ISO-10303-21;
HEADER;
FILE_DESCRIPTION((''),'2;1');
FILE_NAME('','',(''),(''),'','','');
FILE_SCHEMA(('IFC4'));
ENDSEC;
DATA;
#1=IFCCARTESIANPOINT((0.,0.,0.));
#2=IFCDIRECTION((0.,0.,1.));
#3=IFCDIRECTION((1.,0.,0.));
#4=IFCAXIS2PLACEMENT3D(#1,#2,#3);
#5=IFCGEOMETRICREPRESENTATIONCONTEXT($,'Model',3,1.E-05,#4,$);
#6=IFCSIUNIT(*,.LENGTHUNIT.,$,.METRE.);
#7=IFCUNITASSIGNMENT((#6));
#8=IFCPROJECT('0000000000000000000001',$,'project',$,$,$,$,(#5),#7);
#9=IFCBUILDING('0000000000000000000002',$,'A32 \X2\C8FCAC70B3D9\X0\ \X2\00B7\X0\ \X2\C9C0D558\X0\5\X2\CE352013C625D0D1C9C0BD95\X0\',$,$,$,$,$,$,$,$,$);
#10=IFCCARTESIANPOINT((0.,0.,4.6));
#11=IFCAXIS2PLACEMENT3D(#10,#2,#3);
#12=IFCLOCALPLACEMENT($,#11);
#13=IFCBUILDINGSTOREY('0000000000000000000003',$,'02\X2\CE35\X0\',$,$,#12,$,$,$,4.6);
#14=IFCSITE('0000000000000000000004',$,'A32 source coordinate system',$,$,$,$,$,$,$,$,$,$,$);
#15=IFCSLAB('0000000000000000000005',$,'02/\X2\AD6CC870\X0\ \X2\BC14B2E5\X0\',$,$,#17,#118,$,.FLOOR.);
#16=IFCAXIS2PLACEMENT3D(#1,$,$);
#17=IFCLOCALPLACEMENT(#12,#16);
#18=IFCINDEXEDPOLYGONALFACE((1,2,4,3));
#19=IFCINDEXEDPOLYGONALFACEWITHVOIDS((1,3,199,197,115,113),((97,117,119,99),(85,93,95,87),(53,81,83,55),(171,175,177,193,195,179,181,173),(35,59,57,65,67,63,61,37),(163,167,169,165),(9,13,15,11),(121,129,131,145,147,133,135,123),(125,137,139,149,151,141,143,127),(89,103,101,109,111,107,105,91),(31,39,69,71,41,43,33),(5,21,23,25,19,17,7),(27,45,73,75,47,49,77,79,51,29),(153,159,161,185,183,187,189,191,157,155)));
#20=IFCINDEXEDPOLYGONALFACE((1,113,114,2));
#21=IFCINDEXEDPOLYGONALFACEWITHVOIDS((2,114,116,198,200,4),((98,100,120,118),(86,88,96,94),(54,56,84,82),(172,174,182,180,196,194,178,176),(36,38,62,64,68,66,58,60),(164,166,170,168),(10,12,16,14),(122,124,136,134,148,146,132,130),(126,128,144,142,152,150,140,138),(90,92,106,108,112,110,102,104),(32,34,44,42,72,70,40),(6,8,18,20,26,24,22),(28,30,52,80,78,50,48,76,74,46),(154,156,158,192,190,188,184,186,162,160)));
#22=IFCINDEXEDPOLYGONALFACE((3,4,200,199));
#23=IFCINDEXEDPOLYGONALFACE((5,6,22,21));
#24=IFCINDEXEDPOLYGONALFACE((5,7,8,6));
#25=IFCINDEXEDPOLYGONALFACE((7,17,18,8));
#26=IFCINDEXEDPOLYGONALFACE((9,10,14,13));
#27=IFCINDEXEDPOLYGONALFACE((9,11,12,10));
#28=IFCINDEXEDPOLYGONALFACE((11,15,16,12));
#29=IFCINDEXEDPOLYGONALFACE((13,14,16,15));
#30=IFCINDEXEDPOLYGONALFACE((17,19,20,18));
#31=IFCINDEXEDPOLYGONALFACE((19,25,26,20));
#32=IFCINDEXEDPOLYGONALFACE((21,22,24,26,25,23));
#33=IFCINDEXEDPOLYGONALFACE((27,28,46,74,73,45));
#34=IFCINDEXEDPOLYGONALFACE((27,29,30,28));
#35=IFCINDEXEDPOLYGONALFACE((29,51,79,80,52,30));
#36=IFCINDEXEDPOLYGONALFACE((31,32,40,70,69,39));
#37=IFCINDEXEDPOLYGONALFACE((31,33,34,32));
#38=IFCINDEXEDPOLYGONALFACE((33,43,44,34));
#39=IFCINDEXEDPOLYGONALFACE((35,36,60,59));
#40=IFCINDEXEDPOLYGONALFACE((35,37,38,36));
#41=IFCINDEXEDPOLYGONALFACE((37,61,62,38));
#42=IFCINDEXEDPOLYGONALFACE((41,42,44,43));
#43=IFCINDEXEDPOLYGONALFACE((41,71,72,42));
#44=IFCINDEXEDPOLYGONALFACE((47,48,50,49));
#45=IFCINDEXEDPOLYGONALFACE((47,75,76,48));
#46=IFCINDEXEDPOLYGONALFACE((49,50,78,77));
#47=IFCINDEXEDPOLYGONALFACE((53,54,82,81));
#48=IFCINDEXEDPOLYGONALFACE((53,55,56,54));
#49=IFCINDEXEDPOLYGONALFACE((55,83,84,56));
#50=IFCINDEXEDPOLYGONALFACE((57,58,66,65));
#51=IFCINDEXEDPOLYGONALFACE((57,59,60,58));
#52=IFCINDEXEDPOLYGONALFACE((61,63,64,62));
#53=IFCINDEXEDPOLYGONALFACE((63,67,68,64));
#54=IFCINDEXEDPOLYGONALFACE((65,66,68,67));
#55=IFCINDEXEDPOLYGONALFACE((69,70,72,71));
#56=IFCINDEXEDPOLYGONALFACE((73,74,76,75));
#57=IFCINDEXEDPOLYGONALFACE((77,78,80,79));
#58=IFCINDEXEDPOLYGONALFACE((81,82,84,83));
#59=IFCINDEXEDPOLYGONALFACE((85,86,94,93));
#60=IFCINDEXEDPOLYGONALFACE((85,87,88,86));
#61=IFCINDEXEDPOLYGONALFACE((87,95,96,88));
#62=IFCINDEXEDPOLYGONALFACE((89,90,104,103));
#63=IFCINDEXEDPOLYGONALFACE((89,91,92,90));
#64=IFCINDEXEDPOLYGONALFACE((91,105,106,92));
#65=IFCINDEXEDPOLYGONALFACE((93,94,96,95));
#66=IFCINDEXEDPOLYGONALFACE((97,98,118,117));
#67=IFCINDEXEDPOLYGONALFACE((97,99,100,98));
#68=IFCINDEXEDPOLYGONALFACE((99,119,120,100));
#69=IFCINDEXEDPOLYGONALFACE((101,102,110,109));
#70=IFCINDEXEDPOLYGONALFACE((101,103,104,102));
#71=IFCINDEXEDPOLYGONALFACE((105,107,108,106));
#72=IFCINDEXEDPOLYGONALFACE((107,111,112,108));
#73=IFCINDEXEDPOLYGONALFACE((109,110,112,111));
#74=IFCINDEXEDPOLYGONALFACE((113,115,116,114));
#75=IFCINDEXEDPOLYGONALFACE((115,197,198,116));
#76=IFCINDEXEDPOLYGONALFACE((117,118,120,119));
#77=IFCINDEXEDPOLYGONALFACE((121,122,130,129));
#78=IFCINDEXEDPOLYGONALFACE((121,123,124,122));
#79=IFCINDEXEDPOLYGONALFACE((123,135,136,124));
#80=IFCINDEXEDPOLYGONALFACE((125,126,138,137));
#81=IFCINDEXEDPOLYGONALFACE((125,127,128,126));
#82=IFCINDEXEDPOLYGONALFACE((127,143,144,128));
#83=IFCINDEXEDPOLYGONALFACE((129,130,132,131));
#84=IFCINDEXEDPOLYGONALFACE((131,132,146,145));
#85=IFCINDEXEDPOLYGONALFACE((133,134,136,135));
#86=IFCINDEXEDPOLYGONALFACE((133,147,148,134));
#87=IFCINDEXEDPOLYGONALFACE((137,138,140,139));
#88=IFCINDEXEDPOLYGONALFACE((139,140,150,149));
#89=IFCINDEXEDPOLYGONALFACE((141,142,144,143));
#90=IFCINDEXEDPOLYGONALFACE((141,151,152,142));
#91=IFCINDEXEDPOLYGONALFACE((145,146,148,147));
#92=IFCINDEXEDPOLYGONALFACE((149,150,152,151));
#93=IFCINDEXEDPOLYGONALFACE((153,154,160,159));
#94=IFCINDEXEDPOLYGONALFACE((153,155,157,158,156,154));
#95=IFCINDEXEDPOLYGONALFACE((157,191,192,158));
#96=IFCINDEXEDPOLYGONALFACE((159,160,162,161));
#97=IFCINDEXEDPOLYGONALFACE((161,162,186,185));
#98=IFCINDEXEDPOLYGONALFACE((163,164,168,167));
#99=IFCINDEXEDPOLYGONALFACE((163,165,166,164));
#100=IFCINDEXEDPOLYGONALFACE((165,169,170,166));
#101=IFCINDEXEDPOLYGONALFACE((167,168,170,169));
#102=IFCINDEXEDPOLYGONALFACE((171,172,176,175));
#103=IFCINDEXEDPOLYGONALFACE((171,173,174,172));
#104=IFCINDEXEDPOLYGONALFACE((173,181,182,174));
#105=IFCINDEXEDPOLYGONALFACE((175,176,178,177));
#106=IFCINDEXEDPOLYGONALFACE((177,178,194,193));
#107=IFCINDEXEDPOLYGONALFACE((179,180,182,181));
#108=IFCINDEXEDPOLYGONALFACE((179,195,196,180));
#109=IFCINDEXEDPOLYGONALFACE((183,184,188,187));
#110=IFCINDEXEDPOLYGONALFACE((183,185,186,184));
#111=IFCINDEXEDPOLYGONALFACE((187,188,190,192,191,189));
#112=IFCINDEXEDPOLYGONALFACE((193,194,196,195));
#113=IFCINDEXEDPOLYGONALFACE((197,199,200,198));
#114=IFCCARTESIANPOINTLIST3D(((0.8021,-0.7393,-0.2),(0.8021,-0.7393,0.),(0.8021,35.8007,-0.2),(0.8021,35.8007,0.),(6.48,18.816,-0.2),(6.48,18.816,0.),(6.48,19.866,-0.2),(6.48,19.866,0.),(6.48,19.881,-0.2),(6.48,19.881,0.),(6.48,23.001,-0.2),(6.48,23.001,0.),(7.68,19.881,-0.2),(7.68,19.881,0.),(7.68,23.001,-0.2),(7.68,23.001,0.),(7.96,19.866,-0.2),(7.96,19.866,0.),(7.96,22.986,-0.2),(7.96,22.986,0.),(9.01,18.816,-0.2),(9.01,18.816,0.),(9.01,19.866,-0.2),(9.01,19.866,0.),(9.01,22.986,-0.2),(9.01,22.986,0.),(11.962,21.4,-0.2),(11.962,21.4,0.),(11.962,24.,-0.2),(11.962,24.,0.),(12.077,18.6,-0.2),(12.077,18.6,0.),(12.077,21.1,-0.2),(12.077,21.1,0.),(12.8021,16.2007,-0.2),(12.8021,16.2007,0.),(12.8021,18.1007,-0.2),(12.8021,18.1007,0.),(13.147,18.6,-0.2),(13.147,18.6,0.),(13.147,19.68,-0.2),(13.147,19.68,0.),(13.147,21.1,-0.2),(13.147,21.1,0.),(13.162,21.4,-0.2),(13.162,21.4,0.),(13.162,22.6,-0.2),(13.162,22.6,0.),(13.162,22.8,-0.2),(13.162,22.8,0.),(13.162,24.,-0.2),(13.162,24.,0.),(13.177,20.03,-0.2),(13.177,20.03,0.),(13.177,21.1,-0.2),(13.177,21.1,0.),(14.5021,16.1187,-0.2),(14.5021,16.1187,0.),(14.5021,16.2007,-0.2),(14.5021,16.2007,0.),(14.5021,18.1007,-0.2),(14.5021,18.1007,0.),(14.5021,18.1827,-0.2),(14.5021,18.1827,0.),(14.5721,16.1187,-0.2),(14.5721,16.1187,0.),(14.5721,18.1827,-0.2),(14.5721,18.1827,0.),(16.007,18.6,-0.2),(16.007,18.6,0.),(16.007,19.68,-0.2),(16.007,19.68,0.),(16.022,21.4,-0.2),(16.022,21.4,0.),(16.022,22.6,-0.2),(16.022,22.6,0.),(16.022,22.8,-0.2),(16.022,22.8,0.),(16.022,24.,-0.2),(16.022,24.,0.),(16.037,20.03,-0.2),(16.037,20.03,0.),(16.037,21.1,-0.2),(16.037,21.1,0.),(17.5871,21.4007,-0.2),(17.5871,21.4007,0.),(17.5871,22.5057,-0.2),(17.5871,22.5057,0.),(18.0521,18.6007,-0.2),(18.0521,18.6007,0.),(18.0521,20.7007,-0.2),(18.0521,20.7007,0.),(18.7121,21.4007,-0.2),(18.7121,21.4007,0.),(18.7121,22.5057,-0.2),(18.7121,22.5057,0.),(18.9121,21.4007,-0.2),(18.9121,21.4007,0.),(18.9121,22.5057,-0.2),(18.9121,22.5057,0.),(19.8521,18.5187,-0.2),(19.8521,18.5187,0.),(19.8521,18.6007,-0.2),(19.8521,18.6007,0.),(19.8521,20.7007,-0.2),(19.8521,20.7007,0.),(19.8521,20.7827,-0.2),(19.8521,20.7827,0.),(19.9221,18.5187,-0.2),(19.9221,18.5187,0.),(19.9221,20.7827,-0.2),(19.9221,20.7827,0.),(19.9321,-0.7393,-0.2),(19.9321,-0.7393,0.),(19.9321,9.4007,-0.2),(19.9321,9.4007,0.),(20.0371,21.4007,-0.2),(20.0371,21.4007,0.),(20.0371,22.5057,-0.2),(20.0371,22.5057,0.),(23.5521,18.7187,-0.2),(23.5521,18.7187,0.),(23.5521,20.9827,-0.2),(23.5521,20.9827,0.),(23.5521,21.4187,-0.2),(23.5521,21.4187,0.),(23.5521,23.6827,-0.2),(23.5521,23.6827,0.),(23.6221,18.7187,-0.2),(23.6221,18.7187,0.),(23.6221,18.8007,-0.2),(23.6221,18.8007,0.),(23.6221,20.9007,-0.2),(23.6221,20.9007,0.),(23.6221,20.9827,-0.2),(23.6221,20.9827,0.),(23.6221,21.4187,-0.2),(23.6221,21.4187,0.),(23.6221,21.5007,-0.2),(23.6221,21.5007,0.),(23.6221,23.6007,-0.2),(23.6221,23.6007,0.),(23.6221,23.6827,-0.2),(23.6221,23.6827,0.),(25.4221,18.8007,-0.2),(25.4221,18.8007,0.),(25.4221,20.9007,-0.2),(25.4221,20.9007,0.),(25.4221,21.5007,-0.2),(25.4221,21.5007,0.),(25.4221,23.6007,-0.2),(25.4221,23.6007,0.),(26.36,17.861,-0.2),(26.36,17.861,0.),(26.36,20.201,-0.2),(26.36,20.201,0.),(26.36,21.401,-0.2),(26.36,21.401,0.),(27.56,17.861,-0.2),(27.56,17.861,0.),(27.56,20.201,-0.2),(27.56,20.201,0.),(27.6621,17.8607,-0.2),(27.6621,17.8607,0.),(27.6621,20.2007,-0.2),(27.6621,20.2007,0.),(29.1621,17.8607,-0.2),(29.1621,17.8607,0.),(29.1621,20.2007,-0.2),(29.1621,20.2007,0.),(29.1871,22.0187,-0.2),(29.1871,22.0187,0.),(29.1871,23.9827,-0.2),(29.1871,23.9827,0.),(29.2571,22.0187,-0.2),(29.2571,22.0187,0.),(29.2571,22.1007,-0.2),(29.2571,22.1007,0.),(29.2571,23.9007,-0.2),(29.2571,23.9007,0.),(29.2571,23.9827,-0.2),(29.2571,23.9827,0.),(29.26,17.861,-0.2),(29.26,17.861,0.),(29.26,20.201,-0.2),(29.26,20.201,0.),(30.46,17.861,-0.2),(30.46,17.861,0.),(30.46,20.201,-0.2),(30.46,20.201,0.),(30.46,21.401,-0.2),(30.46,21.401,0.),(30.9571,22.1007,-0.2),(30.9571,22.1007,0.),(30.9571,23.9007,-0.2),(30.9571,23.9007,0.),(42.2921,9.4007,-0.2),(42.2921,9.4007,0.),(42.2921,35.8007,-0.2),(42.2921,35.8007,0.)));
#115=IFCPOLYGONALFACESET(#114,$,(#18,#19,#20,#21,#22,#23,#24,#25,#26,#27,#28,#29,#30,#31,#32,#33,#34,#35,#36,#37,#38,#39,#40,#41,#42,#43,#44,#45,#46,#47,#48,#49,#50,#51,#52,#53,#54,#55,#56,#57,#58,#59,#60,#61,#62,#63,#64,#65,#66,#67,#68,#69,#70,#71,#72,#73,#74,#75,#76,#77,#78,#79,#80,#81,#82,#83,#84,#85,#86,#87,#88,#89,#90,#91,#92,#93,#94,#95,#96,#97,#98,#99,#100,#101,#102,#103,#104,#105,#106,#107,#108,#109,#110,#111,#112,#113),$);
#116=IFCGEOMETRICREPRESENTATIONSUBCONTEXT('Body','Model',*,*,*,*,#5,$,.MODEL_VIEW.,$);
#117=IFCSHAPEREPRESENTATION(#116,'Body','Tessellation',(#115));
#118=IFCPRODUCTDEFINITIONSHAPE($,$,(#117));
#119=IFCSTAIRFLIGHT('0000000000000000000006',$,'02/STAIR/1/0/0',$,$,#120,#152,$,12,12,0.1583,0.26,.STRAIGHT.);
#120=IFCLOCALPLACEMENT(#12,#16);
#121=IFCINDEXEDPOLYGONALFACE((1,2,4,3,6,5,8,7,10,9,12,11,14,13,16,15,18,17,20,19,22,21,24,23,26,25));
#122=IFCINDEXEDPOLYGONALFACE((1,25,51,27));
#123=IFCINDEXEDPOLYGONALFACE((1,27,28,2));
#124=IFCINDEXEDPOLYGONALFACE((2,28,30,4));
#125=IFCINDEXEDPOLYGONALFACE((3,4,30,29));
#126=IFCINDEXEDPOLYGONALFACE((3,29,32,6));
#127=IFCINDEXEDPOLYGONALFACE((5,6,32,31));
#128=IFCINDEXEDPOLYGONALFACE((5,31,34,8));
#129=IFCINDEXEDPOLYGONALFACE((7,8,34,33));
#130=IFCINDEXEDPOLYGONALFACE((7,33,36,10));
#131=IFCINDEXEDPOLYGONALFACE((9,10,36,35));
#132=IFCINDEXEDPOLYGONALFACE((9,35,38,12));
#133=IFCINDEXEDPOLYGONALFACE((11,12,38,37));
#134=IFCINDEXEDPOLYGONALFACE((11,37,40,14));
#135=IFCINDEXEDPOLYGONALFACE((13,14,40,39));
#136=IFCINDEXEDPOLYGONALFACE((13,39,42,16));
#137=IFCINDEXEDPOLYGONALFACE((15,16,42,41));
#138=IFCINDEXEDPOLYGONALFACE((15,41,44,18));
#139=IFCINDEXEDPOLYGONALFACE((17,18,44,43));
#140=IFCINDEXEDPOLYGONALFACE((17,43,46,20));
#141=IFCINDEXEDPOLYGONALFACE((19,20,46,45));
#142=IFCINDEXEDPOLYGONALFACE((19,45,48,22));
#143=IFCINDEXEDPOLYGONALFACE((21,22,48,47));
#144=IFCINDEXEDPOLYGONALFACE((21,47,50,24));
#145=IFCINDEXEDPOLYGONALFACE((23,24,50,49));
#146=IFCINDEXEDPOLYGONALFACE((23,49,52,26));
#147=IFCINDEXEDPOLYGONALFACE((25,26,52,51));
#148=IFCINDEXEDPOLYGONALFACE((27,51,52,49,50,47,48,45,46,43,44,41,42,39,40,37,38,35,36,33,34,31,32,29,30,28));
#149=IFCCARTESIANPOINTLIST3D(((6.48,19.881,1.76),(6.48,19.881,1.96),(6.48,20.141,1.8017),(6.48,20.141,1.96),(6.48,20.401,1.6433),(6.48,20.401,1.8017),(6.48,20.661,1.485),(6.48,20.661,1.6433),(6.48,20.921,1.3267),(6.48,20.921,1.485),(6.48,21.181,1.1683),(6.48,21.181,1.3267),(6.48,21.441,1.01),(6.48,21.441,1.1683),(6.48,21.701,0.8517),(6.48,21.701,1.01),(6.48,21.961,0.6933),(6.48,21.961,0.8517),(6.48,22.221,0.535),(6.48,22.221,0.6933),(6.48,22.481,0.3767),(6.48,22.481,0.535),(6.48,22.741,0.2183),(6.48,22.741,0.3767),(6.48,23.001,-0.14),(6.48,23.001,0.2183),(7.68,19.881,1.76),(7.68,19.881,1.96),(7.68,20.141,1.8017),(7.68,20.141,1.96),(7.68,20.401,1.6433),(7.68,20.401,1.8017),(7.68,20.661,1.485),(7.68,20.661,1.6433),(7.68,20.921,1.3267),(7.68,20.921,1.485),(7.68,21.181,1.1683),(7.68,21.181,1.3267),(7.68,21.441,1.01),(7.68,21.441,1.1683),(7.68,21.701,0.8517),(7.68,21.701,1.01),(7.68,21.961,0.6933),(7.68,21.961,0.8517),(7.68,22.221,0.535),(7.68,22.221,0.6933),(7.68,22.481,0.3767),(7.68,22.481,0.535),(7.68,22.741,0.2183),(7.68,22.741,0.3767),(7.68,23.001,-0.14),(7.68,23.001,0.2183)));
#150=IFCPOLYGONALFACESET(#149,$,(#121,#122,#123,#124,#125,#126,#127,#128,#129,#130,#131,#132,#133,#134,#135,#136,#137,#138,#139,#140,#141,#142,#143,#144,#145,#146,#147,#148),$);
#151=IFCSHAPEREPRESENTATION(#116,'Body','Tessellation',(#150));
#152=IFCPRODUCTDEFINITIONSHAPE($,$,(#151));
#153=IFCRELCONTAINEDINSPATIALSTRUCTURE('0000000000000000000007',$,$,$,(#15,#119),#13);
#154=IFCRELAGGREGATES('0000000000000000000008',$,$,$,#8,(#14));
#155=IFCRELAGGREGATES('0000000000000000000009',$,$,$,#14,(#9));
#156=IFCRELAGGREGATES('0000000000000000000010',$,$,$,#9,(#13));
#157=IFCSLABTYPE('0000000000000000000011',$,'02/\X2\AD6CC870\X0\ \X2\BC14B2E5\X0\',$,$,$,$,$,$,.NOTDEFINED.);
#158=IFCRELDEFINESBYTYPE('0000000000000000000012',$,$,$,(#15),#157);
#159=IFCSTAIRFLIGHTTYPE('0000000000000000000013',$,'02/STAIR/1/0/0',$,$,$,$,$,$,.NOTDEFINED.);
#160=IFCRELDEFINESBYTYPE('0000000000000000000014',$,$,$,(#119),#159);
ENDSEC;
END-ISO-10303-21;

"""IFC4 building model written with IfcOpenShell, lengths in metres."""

from ifc_helpers import new_model, si_unit, frame, origin, origin_with_axes, place, context, subcontext, project, spatial, polyline, outline, extrude, source, transform, mapped, type_object, type_shapes, element, save


model = new_model("IFC4")

# Units and contexts
model_context = context("Model", 3, precision=1e-05, world=origin_with_axes())
body_context = subcontext(model_context, "Body", "Model", "MODEL_VIEW")
ifc_project = project(units=[si_unit("LENGTHUNIT", "METRE")], contexts=[model_context])

# Site, building, storey
storey_placement = place(None, frame((0.0, 0.0, 4.6), z_axis=(0.0, 0.0, 1.0), x_axis=(1.0, 0.0, 0.0)))
site = spatial("IfcSite", under=ifc_project, Name="A32 source coordinate system")
building = spatial("IfcBuilding", under=site, Name="A32 주거동 · 지하5층–옥탑지붕")
storey = spatial("IfcBuildingStorey", under=building, at=storey_placement, Name="02층", Elevation=4.6)

# Slab
slab_type_1 = type_object("IfcSlabType", Name="02/구조 바닥", PredefinedType="NOTDEFINED")
shared_shape_1 = source(origin(), body_context, "Body", "SweptSolid", [
    extrude(outline(polyline([(42.2921, 9.4007), (19.9321, 9.4007), (19.9321, -0.7393), (0.8021, -0.7393), (0.8021, 35.8007), (42.2921, 35.8007), (42.2921, 9.4007)]), holes=[polyline([(29.2571, 23.9827), (29.1871, 23.9827), (29.1871, 22.0187), (29.2571, 22.0187), (29.2571, 22.1007), (30.9571, 22.1007), (30.9571, 23.9007), (29.2571, 23.9007), (29.2571, 23.9827)]), polyline([(27.56, 20.201), (29.26, 20.201), (29.26, 17.861), (30.46, 17.861), (30.46, 20.201), (30.46, 20.201), (30.46, 21.401), (26.36, 21.401), (26.36, 20.201), (26.36, 20.201), (26.36, 17.861), (27.56, 17.861), (27.56, 20.201)]), polyline([(29.1621, 17.8607), (29.1621, 17.8607), (29.1621, 17.8607), (29.1621, 20.2007), (29.1621, 20.2007), (29.1621, 20.2007), (27.6621, 20.2007), (27.6621, 20.2007), (27.6621, 17.8607), (27.6621, 17.8607), (29.1621, 17.8607)]), polyline([(23.6221, 20.9827), (23.5521, 20.9827), (23.5521, 18.7187), (23.6221, 18.7187), (23.6221, 18.8007), (25.4221, 18.8007), (25.4221, 20.9007), (23.6221, 20.9007), (23.6221, 20.9827)]), polyline([(23.6221, 23.6827), (23.5521, 23.6827), (23.5521, 21.4187), (23.6221, 21.4187), (23.6221, 21.5007), (25.4221, 21.5007), (25.4221, 23.6007), (23.6221, 23.6007), (23.6221, 23.6827)]), polyline([(18.9121, 22.5057), (18.9121, 22.5057), (18.9121, 21.4007), (18.9121, 21.4007), (18.9121, 21.4007), (20.0371, 21.4007), (20.0371, 22.5057), (18.9121, 22.5057), (18.9121, 22.5057)]), polyline([(19.8521, 18.5187), (19.9221, 18.5187), (19.9221, 20.7827), (19.8521, 20.7827), (19.8521, 20.7007), (18.0521, 20.7007), (18.0521, 18.6007), (19.8521, 18.6007), (19.8521, 18.5187)]), polyline([(17.5871, 21.4007), (17.5871, 21.4007), (18.7121, 21.4007), (18.7121, 22.5057), (17.5871, 22.5057), (17.5871, 22.5057), (17.5871, 21.4007)]), polyline([(16.037, 20.03), (16.037, 21.1), (13.177, 21.1), (13.177, 20.03), (16.037, 20.03)]), polyline([(11.962, 24.0), (11.962, 21.4), (13.162, 21.4), (16.022, 21.4), (16.022, 22.6), (13.162, 22.6), (13.162, 22.8), (16.022, 22.8), (16.022, 24.0), (13.162, 24.0), (13.162, 24.0), (11.962, 24.0)]), polyline([(16.007, 19.68), (13.147, 19.68), (13.147, 21.1), (12.077, 21.1), (12.077, 18.6), (13.147, 18.6), (16.007, 18.6), (16.007, 19.68)]), polyline([(14.5721, 16.1187), (14.5721, 18.1827), (14.5021, 18.1827), (14.5021, 18.1007), (12.8021, 18.1007), (12.8021, 16.2007), (14.5021, 16.2007), (14.5021, 16.1187), (14.5721, 16.1187)]), polyline([(9.01, 18.816), (9.01, 19.866), (9.01, 19.866), (9.01, 22.986), (7.96, 22.986), (7.96, 19.866), (6.48, 19.866), (6.48, 18.816), (9.01, 18.816)]), polyline([(7.68, 23.001), (6.48, 23.001), (6.48, 19.881), (7.68, 19.881), (7.68, 23.001)])]), frame((0.0, 0.0, -0.2)), (0.0, 0.0, 1.0), 0.2),
])
type_shapes(slab_type_1, [shared_shape_1])
slab_1_placement = place(storey_placement, origin_with_axes())
element("IfcSlab", 1, at=slab_1_placement, inside=storey, type_object=slab_type_1, Name="02/구조 바닥", PredefinedType="FLOOR", context=body_context, shape_type="MappedRepresentation", body=[
    mapped(shared_shape_1, transform((0.0, 0.0, 0.0), scale=1.0)),
])

# Stair flight
stair_flight_type_1 = type_object("IfcStairFlightType", Name="02/STAIR/1/0/0", PredefinedType="NOTDEFINED")
shared_shape_2 = source(origin(), body_context, "Body", "SweptSolid", [
    extrude(outline(polyline([(0.0, -0.14), (3.12, 1.76), (3.12, 1.96), (2.86, 1.96), (2.86, 1.8017), (2.6, 1.8017), (2.6, 1.6433), (2.34, 1.6433), (2.34, 1.485), (2.08, 1.485), (2.08, 1.3267), (1.82, 1.3267), (1.82, 1.1683), (1.56, 1.1683), (1.56, 1.01), (1.3, 1.01), (1.3, 0.8517), (1.04, 0.8517), (1.04, 0.6933), (0.78, 0.6933), (0.78, 0.535), (0.52, 0.535), (0.52, 0.3767), (0.26, 0.3767), (0.26, 0.2183), (0.0, 0.2183), (0.0, -0.14)])), frame((7.68, 23.001, 0.0), z_axis=(-1.0, 0.0, 0.0), x_axis=(0.0, -1.0, 0.0)), (0.0, 0.0, 1.0), 1.2),
])
type_shapes(stair_flight_type_1, [shared_shape_2])
stair_flight_1_placement = place(storey_placement, origin_with_axes())
element("IfcStairFlight", 2, at=stair_flight_1_placement, inside=storey, type_object=stair_flight_type_1, Name="02/STAIR/1/0/0", NumberOfRisers=12, NumberOfTreads=12, PredefinedType="STRAIGHT", RiserHeight=0.1583, TreadLength=0.26, context=body_context, shape_type="MappedRepresentation", body=[
    mapped(shared_shape_2, transform((0.0, 0.0, 0.0), scale=1.0)),
])

save(model, "model.ifc")
